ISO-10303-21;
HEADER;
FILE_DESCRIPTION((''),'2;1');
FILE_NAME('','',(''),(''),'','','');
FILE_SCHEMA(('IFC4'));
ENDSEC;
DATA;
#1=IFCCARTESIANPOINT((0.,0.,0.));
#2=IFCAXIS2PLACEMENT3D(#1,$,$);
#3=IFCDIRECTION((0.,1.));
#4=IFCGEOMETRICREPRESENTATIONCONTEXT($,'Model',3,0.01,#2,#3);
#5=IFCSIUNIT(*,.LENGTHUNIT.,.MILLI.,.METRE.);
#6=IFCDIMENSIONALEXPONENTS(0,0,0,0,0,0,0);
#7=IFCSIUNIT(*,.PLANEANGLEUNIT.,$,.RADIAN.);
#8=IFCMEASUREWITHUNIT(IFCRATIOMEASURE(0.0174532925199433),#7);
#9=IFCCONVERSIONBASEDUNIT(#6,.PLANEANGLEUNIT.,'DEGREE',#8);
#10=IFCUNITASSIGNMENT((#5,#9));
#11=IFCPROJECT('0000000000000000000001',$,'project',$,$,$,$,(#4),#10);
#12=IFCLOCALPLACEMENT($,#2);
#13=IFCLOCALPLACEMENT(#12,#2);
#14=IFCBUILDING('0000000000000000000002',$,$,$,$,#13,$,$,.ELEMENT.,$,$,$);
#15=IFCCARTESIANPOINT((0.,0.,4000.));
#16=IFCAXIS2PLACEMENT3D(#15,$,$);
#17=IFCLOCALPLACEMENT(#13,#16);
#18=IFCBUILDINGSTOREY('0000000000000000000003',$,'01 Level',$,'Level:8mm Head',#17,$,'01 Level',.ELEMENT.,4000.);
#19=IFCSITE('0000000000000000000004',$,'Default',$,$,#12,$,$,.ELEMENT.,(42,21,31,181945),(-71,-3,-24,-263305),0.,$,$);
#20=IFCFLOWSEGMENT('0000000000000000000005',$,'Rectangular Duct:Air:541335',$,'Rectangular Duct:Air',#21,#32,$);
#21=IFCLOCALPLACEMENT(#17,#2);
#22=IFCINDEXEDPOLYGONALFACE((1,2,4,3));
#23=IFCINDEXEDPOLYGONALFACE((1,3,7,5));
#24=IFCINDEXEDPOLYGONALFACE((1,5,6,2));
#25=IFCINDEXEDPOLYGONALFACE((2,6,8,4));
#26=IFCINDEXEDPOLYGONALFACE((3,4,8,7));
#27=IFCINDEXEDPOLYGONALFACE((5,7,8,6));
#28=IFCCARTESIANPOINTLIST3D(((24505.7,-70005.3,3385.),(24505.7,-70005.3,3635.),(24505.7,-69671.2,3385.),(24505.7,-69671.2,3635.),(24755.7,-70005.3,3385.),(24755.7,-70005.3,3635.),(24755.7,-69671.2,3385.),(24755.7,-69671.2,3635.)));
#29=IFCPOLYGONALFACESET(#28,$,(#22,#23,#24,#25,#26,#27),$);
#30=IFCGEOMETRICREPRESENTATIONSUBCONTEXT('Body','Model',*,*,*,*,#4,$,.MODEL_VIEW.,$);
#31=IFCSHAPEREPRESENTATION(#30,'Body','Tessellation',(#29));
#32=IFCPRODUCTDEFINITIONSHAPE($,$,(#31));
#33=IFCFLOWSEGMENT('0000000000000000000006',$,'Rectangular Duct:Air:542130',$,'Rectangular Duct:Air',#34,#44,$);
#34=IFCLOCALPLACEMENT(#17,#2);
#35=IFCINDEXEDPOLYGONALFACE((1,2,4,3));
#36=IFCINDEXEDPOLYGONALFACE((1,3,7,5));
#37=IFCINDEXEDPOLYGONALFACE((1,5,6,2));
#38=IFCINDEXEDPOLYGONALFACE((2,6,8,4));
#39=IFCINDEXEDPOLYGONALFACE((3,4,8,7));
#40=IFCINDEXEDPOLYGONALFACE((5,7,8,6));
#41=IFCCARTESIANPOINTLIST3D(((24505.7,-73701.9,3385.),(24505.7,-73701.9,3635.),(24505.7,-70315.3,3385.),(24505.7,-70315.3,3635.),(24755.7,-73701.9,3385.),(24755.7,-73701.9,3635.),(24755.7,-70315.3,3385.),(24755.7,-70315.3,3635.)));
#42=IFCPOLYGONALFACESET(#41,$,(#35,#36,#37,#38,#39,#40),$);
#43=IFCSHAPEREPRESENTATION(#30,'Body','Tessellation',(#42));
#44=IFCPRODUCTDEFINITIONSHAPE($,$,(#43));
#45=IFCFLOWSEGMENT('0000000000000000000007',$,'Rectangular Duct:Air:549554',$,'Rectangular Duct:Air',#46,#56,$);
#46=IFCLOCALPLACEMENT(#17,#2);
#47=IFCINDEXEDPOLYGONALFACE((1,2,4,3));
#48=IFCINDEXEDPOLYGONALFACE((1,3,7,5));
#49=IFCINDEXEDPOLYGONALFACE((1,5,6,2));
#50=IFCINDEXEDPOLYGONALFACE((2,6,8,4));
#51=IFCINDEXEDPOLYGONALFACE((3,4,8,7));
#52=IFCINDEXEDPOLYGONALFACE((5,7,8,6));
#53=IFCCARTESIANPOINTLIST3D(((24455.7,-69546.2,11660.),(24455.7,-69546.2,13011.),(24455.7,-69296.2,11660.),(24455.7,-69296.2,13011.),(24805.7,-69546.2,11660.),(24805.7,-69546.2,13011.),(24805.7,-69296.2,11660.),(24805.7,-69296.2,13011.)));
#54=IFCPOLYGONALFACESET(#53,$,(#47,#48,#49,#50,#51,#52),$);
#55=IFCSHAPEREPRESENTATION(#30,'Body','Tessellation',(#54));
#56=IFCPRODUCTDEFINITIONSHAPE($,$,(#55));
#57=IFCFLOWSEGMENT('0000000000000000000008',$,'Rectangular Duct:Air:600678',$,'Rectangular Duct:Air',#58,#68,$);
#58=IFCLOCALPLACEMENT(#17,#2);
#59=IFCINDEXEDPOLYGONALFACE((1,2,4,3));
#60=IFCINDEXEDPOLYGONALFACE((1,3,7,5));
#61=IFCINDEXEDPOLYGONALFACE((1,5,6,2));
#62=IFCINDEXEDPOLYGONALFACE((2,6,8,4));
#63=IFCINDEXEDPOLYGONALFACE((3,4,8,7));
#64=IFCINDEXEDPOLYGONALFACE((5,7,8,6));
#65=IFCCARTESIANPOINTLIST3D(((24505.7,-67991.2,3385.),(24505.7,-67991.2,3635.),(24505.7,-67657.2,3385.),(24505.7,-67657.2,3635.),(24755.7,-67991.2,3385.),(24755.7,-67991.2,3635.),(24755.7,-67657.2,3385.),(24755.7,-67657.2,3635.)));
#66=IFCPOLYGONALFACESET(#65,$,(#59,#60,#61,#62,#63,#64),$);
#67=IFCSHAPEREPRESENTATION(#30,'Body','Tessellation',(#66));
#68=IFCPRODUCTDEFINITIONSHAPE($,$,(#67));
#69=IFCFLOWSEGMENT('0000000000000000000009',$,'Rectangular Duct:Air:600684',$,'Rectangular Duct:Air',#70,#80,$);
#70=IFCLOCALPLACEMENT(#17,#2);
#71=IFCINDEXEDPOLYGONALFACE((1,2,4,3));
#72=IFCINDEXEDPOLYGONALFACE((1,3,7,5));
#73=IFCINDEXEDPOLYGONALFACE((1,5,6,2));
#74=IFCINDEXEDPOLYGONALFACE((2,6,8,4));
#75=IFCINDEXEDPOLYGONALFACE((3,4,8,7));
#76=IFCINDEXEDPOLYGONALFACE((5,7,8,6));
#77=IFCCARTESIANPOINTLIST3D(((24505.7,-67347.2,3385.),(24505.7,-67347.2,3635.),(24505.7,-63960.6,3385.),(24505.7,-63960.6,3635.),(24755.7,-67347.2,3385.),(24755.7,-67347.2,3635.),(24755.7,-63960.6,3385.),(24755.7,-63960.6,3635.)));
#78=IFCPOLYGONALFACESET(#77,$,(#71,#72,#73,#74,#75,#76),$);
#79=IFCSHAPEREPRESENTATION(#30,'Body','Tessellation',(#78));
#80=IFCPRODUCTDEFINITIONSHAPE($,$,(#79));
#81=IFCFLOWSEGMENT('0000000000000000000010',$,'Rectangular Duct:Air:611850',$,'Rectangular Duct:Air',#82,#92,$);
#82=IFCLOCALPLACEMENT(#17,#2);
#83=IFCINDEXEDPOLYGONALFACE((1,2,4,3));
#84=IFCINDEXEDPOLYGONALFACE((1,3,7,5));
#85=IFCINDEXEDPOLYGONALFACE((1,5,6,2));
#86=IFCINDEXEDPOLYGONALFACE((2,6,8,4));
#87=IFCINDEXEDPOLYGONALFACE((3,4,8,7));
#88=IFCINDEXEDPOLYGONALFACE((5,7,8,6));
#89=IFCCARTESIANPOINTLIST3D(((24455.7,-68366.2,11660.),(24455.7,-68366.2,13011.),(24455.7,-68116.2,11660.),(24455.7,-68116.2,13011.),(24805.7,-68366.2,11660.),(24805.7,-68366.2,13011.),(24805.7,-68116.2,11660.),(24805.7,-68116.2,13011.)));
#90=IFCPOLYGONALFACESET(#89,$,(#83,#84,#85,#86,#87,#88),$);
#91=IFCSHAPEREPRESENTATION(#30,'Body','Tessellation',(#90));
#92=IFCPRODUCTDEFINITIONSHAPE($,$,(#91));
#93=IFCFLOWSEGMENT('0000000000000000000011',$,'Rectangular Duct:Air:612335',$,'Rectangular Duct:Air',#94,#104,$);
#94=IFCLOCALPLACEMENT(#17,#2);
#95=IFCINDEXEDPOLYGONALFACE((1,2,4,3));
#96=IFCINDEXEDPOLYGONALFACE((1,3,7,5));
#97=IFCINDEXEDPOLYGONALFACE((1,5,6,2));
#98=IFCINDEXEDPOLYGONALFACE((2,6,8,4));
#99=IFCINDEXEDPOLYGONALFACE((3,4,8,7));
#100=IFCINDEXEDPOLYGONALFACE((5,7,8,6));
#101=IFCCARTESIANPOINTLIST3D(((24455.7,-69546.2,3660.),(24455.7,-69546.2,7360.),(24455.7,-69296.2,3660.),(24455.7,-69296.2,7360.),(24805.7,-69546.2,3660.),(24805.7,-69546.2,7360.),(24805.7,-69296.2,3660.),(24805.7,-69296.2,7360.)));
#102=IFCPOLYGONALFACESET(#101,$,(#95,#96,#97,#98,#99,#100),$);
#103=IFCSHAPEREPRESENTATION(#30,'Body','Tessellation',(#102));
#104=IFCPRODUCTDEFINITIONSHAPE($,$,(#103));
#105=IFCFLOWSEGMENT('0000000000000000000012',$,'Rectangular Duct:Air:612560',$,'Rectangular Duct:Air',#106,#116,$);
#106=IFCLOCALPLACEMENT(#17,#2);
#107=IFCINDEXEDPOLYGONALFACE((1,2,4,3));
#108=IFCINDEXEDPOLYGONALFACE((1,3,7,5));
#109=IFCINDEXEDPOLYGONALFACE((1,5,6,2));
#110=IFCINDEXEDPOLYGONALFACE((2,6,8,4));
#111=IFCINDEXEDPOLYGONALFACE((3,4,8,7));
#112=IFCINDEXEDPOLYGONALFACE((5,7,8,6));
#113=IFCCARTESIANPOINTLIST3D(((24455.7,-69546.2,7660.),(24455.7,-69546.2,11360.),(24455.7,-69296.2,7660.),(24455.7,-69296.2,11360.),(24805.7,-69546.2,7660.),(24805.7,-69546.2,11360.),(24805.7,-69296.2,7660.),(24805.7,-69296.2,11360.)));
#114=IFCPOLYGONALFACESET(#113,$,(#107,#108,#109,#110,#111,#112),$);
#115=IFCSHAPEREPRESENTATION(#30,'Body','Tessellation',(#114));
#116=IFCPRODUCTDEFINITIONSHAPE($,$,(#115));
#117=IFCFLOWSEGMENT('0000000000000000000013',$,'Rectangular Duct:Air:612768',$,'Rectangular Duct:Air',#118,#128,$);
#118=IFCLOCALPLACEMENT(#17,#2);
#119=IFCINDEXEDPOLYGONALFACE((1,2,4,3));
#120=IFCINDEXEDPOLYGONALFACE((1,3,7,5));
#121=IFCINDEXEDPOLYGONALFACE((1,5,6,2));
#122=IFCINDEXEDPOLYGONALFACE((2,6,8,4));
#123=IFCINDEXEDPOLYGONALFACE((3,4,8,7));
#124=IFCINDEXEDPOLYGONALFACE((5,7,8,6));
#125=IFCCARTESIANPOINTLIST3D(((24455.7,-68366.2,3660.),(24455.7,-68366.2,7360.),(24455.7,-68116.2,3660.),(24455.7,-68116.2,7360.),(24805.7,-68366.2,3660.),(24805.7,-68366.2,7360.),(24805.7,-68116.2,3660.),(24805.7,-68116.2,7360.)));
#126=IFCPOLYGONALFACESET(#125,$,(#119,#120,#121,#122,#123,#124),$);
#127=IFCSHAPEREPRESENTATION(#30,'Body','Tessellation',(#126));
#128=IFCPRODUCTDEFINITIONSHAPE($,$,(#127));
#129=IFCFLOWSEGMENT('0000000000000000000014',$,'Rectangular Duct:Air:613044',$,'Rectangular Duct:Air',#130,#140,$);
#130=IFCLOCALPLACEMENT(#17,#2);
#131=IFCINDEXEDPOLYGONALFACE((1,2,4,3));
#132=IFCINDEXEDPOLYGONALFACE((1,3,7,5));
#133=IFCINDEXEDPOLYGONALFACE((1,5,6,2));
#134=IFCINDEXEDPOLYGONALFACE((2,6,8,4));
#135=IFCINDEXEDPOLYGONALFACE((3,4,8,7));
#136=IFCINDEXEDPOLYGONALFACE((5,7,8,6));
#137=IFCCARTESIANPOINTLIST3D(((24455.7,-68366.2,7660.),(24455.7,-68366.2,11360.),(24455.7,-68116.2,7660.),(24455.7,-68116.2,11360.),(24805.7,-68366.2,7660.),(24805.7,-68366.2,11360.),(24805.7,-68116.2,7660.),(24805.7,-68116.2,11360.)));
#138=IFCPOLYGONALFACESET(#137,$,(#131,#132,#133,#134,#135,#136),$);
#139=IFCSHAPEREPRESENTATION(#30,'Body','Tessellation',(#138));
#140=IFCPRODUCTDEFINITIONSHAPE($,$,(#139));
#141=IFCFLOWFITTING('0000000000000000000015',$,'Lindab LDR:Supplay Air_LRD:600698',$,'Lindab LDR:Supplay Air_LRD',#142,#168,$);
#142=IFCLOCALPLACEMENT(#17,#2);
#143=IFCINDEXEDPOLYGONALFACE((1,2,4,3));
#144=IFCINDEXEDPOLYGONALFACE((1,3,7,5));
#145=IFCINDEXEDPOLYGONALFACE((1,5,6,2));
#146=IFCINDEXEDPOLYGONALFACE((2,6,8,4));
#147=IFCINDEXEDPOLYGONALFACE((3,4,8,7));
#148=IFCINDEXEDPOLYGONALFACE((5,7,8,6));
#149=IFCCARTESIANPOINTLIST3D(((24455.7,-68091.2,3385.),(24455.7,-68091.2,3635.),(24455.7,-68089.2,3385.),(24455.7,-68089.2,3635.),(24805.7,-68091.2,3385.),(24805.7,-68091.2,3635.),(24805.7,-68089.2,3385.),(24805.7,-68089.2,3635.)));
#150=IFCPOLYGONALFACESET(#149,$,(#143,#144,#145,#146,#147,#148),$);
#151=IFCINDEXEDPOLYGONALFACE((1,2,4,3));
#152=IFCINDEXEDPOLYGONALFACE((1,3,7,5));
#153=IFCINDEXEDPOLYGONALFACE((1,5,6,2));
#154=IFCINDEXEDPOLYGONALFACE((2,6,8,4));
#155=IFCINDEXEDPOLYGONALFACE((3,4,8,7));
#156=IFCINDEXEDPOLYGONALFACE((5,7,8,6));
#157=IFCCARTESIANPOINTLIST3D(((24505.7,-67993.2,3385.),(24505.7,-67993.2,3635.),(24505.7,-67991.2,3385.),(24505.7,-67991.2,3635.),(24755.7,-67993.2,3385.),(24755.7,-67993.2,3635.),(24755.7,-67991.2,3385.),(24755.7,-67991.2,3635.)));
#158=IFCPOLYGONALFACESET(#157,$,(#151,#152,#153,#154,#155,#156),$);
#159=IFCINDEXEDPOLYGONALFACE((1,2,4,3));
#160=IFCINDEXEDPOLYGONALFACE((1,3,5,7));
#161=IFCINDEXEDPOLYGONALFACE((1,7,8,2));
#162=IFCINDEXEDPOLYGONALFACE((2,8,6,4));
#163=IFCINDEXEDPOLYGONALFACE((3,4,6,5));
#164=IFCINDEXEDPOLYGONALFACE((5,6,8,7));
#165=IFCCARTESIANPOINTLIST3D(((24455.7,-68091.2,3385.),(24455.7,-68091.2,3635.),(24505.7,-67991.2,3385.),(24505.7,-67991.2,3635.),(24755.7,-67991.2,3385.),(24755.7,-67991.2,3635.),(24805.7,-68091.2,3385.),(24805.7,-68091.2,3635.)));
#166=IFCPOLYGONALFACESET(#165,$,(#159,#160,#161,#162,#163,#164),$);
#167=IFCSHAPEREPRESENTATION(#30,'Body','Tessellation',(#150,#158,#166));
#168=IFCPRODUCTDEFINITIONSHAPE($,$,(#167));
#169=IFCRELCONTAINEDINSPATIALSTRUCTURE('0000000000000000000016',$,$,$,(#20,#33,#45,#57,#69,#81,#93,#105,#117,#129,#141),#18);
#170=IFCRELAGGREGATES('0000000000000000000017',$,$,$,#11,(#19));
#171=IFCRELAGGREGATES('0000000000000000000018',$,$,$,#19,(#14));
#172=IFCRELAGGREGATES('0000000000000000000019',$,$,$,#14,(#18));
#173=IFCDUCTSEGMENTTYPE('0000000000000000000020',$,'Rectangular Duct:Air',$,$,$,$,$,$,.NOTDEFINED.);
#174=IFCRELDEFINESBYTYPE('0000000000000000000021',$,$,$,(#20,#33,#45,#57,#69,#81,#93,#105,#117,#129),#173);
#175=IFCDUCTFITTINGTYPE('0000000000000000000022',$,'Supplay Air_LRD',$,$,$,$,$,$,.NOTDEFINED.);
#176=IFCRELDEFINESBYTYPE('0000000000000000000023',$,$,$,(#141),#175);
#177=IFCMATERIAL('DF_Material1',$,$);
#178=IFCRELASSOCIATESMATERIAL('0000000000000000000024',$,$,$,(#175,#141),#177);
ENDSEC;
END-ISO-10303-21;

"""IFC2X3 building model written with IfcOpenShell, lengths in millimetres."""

from ifc_helpers import new_model, entity, si_unit, converted_unit, direction, frame, frame_2d, origin, origin_2d_with_axis, place, context, subcontext, project, spatial, polyline, rectangle, outline, extrude, source, transform, mapped, material, type_object, type_shapes, element, save


model = new_model("IFC2X3")

# Units and contexts
model_context = context("Model", 3, precision=0.01, world=origin(), true_north=direction((0.0, 1.0)))
body_context = subcontext(model_context, "Body", "Model", "MODEL_VIEW")
ifc_project = project(units=[si_unit("LENGTHUNIT", "METRE", prefix="MILLI"), converted_unit("PLANEANGLEUNIT", "DEGREE", entity("IfcRatioMeasure", 0.0174532925199433), si_unit("PLANEANGLEUNIT", "RADIAN"), dimensions=[0, 0, 0, 0, 0, 0, 0])], contexts=[model_context])

# Site, building, storey
site_placement = place(None, origin())
site = spatial("IfcSite", under=ifc_project, at=site_placement, Name="Default", CompositionType="ELEMENT", RefLatitude=(42, 21, 31, 181945), RefLongitude=(-71, -3, -24, -263305), RefElevation=0.0)
building_placement = place(site_placement, origin())
building = spatial("IfcBuilding", under=site, at=building_placement, CompositionType="ELEMENT")
storey_placement = place(building_placement, frame((0.0, 0.0, 4000.0)))
storey = spatial("IfcBuildingStorey", under=building, at=storey_placement, Name="01 Level", ObjectType="Level:8mm Head", LongName="01 Level", CompositionType="ELEMENT", Elevation=4000.0)

# Flow segments
duct_segment_type_1 = type_object("IfcDuctSegmentType", Name="Rectangular Duct:Air", PredefinedType="NOTDEFINED")
flow_segment_1_placement = place(storey_placement, frame((24505.7, -70005.3, 3385.0)))
element("IfcFlowSegment", 1, at=flow_segment_1_placement, inside=storey, type_object=duct_segment_type_1, Name="Rectangular Duct:Air:541335", ObjectType="Rectangular Duct:Air", context=body_context, shape_type="SweptSolid", body=[
    extrude(rectangle(XDim=334.0, YDim=250.0, at=frame_2d((0.0, 0.0), x_axis=(1.0, 0.0))), frame((125.0, 167.0, 0.0), z_axis=(0.0, 0.0, 1.0), x_axis=(0.0, 1.0, 0.0)), (0.0, 0.0, 1.0), 250.0),
])
flow_segment_2_placement = place(storey_placement, frame((24505.7, -73701.9, 3385.0)))
element("IfcFlowSegment", 2, at=flow_segment_2_placement, inside=storey, type_object=duct_segment_type_1, Name="Rectangular Duct:Air:542130", ObjectType="Rectangular Duct:Air", context=body_context, shape_type="SweptSolid", body=[
    extrude(rectangle(XDim=3386.6, YDim=250.0, at=frame_2d((0.0, 0.0), x_axis=(1.0, 0.0))), frame((125.0, 1693.3, 0.0), z_axis=(0.0, 0.0, 1.0), x_axis=(0.0, 1.0, 0.0)), (0.0, 0.0, 1.0), 250.0),
])
flow_segment_3_placement = place(storey_placement, frame((24455.7, -69546.2, 11660.0)))
element("IfcFlowSegment", 3, at=flow_segment_3_placement, inside=storey, type_object=duct_segment_type_1, Name="Rectangular Duct:Air:549554", ObjectType="Rectangular Duct:Air", context=body_context, shape_type="SweptSolid", body=[
    extrude(rectangle(XDim=350.0, YDim=250.0, at=frame_2d((0.0, 0.0), x_axis=(1.0, 0.0))), frame((175.0, 125.0, 0.0)), (0.0, 0.0, 1.0), 1351.0),
])
flow_segment_4_placement = place(storey_placement, frame((24505.7, -67991.2, 3385.0)))
element("IfcFlowSegment", 4, at=flow_segment_4_placement, inside=storey, type_object=duct_segment_type_1, Name="Rectangular Duct:Air:600678", ObjectType="Rectangular Duct:Air", context=body_context, shape_type="SweptSolid", body=[
    extrude(rectangle(XDim=334.0, YDim=250.0, at=frame_2d((0.0, 0.0), x_axis=(1.0, 0.0))), frame((125.0, 167.0, 0.0), z_axis=(0.0, 0.0, 1.0), x_axis=(0.0, -1.0, 0.0)), (0.0, 0.0, 1.0), 250.0),
])
flow_segment_5_placement = place(storey_placement, frame((24505.7, -67347.2, 3385.0)))
element("IfcFlowSegment", 5, at=flow_segment_5_placement, inside=storey, type_object=duct_segment_type_1, Name="Rectangular Duct:Air:600684", ObjectType="Rectangular Duct:Air", context=body_context, shape_type="SweptSolid", body=[
    extrude(rectangle(XDim=3386.6, YDim=250.0, at=frame_2d((0.0, 0.0), x_axis=(1.0, 0.0))), frame((125.0, 1693.3, 0.0), z_axis=(0.0, 0.0, 1.0), x_axis=(0.0, -1.0, 0.0)), (0.0, 0.0, 1.0), 250.0),
])
flow_segment_6_placement = place(storey_placement, frame((24455.7, -68366.2, 11660.0)))
element("IfcFlowSegment", 6, at=flow_segment_6_placement, inside=storey, type_object=duct_segment_type_1, Name="Rectangular Duct:Air:611850", ObjectType="Rectangular Duct:Air", context=body_context, shape_type="SweptSolid", body=[
    extrude(rectangle(XDim=250.0, YDim=350.0, at=frame_2d((0.0, 0.0), x_axis=(1.0, 0.0))), frame((175.0, 125.0, 0.0), z_axis=(0.0, 0.0, 1.0), x_axis=(0.0, -1.0, 0.0)), (0.0, 0.0, 1.0), 1351.0),
])
for number, where, name in (
    (7, (24455.7, -69546.2, 3660.0), "Rectangular Duct:Air:612335"),
    (8, (24455.7, -69546.2, 7660.0), "Rectangular Duct:Air:612560"),
):
    element("IfcFlowSegment", number, at=place(storey_placement, frame(where)), inside=storey, type_object=duct_segment_type_1, Name=name, ObjectType="Rectangular Duct:Air", context=body_context, shape_type="SweptSolid", body=[
        extrude(rectangle(XDim=250.0, YDim=350.0, at=frame_2d((0.0, 0.0), x_axis=(1.0, 0.0))), frame((175.0, 125.0, 0.0), z_axis=(0.0, 0.0, 1.0), x_axis=(0.0, 1.0, 0.0)), (0.0, 0.0, 1.0), 3700.0),
    ])
for number, where, name in (
    (9, (24455.7, -68366.2, 3660.0), "Rectangular Duct:Air:612768"),
    (10, (24455.7, -68366.2, 7660.0), "Rectangular Duct:Air:613044"),
):
    element("IfcFlowSegment", number, at=place(storey_placement, frame(where)), inside=storey, type_object=duct_segment_type_1, Name=name, ObjectType="Rectangular Duct:Air", context=body_context, shape_type="SweptSolid", body=[
        extrude(rectangle(XDim=250.0, YDim=350.0, at=frame_2d((0.0, 0.0), x_axis=(1.0, 0.0))), frame((175.0, 125.0, 0.0), z_axis=(0.0, 0.0, 1.0), x_axis=(0.0, -1.0, 0.0)), (0.0, 0.0, 1.0), 3700.0),
    ])

# Flow fitting
ifc_material = material(Name="DF_Material1")
duct_fitting_type_1 = type_object("IfcDuctFittingType", Name="Supplay Air_LRD", PredefinedType="NOTDEFINED", material=ifc_material)
shared_shape_1 = source(origin(), body_context, "Body", "SweptSolid", [
    extrude(rectangle(XDim=350.0, YDim=2.0, at=origin_2d_with_axis()), frame((99.0, 0.0, -125.0), z_axis=(0.0, 0.0, 1.0), x_axis=(0.0, 1.0, 0.0)), (0.0, 0.0, 1.0), 250.0),
    extrude(rectangle(XDim=250.0, YDim=2.0, at=origin_2d_with_axis()), frame((1.0, 0.0, -125.0), z_axis=(0.0, 0.0, 1.0), x_axis=(0.0, 1.0, 0.0)), (0.0, 0.0, 1.0), 250.0),
    extrude(outline(polyline([(-125.0, -50.0), (125.0, -50.0), (175.0, 50.0), (-175.0, 50.0), (-125.0, -50.0)])), frame((50.0, 0.0, -125.0), z_axis=(0.0, 0.0, 1.0), x_axis=(0.0, -1.0, 0.0)), (0.0, 0.0, 1.0), 250.0),
])
type_shapes(duct_fitting_type_1, [shared_shape_1])
flow_fitting_1_placement = place(storey_placement, frame((24630.7, -67991.2, 3510.0), z_axis=(0.0, 0.0, 1.0), x_axis=(0.0, -1.0, 0.0)))
element("IfcFlowFitting", 11, at=flow_fitting_1_placement, inside=storey, type_object=duct_fitting_type_1, material=ifc_material, Name="Lindab LDR:Supplay Air_LRD:600698", ObjectType="Lindab LDR:Supplay Air_LRD", context=body_context, shape_type="MappedRepresentation", body=[
    mapped(shared_shape_1, transform((0.0, 0.0, 0.0), scale=1.0)),
])

save(model, "model.ifc")
